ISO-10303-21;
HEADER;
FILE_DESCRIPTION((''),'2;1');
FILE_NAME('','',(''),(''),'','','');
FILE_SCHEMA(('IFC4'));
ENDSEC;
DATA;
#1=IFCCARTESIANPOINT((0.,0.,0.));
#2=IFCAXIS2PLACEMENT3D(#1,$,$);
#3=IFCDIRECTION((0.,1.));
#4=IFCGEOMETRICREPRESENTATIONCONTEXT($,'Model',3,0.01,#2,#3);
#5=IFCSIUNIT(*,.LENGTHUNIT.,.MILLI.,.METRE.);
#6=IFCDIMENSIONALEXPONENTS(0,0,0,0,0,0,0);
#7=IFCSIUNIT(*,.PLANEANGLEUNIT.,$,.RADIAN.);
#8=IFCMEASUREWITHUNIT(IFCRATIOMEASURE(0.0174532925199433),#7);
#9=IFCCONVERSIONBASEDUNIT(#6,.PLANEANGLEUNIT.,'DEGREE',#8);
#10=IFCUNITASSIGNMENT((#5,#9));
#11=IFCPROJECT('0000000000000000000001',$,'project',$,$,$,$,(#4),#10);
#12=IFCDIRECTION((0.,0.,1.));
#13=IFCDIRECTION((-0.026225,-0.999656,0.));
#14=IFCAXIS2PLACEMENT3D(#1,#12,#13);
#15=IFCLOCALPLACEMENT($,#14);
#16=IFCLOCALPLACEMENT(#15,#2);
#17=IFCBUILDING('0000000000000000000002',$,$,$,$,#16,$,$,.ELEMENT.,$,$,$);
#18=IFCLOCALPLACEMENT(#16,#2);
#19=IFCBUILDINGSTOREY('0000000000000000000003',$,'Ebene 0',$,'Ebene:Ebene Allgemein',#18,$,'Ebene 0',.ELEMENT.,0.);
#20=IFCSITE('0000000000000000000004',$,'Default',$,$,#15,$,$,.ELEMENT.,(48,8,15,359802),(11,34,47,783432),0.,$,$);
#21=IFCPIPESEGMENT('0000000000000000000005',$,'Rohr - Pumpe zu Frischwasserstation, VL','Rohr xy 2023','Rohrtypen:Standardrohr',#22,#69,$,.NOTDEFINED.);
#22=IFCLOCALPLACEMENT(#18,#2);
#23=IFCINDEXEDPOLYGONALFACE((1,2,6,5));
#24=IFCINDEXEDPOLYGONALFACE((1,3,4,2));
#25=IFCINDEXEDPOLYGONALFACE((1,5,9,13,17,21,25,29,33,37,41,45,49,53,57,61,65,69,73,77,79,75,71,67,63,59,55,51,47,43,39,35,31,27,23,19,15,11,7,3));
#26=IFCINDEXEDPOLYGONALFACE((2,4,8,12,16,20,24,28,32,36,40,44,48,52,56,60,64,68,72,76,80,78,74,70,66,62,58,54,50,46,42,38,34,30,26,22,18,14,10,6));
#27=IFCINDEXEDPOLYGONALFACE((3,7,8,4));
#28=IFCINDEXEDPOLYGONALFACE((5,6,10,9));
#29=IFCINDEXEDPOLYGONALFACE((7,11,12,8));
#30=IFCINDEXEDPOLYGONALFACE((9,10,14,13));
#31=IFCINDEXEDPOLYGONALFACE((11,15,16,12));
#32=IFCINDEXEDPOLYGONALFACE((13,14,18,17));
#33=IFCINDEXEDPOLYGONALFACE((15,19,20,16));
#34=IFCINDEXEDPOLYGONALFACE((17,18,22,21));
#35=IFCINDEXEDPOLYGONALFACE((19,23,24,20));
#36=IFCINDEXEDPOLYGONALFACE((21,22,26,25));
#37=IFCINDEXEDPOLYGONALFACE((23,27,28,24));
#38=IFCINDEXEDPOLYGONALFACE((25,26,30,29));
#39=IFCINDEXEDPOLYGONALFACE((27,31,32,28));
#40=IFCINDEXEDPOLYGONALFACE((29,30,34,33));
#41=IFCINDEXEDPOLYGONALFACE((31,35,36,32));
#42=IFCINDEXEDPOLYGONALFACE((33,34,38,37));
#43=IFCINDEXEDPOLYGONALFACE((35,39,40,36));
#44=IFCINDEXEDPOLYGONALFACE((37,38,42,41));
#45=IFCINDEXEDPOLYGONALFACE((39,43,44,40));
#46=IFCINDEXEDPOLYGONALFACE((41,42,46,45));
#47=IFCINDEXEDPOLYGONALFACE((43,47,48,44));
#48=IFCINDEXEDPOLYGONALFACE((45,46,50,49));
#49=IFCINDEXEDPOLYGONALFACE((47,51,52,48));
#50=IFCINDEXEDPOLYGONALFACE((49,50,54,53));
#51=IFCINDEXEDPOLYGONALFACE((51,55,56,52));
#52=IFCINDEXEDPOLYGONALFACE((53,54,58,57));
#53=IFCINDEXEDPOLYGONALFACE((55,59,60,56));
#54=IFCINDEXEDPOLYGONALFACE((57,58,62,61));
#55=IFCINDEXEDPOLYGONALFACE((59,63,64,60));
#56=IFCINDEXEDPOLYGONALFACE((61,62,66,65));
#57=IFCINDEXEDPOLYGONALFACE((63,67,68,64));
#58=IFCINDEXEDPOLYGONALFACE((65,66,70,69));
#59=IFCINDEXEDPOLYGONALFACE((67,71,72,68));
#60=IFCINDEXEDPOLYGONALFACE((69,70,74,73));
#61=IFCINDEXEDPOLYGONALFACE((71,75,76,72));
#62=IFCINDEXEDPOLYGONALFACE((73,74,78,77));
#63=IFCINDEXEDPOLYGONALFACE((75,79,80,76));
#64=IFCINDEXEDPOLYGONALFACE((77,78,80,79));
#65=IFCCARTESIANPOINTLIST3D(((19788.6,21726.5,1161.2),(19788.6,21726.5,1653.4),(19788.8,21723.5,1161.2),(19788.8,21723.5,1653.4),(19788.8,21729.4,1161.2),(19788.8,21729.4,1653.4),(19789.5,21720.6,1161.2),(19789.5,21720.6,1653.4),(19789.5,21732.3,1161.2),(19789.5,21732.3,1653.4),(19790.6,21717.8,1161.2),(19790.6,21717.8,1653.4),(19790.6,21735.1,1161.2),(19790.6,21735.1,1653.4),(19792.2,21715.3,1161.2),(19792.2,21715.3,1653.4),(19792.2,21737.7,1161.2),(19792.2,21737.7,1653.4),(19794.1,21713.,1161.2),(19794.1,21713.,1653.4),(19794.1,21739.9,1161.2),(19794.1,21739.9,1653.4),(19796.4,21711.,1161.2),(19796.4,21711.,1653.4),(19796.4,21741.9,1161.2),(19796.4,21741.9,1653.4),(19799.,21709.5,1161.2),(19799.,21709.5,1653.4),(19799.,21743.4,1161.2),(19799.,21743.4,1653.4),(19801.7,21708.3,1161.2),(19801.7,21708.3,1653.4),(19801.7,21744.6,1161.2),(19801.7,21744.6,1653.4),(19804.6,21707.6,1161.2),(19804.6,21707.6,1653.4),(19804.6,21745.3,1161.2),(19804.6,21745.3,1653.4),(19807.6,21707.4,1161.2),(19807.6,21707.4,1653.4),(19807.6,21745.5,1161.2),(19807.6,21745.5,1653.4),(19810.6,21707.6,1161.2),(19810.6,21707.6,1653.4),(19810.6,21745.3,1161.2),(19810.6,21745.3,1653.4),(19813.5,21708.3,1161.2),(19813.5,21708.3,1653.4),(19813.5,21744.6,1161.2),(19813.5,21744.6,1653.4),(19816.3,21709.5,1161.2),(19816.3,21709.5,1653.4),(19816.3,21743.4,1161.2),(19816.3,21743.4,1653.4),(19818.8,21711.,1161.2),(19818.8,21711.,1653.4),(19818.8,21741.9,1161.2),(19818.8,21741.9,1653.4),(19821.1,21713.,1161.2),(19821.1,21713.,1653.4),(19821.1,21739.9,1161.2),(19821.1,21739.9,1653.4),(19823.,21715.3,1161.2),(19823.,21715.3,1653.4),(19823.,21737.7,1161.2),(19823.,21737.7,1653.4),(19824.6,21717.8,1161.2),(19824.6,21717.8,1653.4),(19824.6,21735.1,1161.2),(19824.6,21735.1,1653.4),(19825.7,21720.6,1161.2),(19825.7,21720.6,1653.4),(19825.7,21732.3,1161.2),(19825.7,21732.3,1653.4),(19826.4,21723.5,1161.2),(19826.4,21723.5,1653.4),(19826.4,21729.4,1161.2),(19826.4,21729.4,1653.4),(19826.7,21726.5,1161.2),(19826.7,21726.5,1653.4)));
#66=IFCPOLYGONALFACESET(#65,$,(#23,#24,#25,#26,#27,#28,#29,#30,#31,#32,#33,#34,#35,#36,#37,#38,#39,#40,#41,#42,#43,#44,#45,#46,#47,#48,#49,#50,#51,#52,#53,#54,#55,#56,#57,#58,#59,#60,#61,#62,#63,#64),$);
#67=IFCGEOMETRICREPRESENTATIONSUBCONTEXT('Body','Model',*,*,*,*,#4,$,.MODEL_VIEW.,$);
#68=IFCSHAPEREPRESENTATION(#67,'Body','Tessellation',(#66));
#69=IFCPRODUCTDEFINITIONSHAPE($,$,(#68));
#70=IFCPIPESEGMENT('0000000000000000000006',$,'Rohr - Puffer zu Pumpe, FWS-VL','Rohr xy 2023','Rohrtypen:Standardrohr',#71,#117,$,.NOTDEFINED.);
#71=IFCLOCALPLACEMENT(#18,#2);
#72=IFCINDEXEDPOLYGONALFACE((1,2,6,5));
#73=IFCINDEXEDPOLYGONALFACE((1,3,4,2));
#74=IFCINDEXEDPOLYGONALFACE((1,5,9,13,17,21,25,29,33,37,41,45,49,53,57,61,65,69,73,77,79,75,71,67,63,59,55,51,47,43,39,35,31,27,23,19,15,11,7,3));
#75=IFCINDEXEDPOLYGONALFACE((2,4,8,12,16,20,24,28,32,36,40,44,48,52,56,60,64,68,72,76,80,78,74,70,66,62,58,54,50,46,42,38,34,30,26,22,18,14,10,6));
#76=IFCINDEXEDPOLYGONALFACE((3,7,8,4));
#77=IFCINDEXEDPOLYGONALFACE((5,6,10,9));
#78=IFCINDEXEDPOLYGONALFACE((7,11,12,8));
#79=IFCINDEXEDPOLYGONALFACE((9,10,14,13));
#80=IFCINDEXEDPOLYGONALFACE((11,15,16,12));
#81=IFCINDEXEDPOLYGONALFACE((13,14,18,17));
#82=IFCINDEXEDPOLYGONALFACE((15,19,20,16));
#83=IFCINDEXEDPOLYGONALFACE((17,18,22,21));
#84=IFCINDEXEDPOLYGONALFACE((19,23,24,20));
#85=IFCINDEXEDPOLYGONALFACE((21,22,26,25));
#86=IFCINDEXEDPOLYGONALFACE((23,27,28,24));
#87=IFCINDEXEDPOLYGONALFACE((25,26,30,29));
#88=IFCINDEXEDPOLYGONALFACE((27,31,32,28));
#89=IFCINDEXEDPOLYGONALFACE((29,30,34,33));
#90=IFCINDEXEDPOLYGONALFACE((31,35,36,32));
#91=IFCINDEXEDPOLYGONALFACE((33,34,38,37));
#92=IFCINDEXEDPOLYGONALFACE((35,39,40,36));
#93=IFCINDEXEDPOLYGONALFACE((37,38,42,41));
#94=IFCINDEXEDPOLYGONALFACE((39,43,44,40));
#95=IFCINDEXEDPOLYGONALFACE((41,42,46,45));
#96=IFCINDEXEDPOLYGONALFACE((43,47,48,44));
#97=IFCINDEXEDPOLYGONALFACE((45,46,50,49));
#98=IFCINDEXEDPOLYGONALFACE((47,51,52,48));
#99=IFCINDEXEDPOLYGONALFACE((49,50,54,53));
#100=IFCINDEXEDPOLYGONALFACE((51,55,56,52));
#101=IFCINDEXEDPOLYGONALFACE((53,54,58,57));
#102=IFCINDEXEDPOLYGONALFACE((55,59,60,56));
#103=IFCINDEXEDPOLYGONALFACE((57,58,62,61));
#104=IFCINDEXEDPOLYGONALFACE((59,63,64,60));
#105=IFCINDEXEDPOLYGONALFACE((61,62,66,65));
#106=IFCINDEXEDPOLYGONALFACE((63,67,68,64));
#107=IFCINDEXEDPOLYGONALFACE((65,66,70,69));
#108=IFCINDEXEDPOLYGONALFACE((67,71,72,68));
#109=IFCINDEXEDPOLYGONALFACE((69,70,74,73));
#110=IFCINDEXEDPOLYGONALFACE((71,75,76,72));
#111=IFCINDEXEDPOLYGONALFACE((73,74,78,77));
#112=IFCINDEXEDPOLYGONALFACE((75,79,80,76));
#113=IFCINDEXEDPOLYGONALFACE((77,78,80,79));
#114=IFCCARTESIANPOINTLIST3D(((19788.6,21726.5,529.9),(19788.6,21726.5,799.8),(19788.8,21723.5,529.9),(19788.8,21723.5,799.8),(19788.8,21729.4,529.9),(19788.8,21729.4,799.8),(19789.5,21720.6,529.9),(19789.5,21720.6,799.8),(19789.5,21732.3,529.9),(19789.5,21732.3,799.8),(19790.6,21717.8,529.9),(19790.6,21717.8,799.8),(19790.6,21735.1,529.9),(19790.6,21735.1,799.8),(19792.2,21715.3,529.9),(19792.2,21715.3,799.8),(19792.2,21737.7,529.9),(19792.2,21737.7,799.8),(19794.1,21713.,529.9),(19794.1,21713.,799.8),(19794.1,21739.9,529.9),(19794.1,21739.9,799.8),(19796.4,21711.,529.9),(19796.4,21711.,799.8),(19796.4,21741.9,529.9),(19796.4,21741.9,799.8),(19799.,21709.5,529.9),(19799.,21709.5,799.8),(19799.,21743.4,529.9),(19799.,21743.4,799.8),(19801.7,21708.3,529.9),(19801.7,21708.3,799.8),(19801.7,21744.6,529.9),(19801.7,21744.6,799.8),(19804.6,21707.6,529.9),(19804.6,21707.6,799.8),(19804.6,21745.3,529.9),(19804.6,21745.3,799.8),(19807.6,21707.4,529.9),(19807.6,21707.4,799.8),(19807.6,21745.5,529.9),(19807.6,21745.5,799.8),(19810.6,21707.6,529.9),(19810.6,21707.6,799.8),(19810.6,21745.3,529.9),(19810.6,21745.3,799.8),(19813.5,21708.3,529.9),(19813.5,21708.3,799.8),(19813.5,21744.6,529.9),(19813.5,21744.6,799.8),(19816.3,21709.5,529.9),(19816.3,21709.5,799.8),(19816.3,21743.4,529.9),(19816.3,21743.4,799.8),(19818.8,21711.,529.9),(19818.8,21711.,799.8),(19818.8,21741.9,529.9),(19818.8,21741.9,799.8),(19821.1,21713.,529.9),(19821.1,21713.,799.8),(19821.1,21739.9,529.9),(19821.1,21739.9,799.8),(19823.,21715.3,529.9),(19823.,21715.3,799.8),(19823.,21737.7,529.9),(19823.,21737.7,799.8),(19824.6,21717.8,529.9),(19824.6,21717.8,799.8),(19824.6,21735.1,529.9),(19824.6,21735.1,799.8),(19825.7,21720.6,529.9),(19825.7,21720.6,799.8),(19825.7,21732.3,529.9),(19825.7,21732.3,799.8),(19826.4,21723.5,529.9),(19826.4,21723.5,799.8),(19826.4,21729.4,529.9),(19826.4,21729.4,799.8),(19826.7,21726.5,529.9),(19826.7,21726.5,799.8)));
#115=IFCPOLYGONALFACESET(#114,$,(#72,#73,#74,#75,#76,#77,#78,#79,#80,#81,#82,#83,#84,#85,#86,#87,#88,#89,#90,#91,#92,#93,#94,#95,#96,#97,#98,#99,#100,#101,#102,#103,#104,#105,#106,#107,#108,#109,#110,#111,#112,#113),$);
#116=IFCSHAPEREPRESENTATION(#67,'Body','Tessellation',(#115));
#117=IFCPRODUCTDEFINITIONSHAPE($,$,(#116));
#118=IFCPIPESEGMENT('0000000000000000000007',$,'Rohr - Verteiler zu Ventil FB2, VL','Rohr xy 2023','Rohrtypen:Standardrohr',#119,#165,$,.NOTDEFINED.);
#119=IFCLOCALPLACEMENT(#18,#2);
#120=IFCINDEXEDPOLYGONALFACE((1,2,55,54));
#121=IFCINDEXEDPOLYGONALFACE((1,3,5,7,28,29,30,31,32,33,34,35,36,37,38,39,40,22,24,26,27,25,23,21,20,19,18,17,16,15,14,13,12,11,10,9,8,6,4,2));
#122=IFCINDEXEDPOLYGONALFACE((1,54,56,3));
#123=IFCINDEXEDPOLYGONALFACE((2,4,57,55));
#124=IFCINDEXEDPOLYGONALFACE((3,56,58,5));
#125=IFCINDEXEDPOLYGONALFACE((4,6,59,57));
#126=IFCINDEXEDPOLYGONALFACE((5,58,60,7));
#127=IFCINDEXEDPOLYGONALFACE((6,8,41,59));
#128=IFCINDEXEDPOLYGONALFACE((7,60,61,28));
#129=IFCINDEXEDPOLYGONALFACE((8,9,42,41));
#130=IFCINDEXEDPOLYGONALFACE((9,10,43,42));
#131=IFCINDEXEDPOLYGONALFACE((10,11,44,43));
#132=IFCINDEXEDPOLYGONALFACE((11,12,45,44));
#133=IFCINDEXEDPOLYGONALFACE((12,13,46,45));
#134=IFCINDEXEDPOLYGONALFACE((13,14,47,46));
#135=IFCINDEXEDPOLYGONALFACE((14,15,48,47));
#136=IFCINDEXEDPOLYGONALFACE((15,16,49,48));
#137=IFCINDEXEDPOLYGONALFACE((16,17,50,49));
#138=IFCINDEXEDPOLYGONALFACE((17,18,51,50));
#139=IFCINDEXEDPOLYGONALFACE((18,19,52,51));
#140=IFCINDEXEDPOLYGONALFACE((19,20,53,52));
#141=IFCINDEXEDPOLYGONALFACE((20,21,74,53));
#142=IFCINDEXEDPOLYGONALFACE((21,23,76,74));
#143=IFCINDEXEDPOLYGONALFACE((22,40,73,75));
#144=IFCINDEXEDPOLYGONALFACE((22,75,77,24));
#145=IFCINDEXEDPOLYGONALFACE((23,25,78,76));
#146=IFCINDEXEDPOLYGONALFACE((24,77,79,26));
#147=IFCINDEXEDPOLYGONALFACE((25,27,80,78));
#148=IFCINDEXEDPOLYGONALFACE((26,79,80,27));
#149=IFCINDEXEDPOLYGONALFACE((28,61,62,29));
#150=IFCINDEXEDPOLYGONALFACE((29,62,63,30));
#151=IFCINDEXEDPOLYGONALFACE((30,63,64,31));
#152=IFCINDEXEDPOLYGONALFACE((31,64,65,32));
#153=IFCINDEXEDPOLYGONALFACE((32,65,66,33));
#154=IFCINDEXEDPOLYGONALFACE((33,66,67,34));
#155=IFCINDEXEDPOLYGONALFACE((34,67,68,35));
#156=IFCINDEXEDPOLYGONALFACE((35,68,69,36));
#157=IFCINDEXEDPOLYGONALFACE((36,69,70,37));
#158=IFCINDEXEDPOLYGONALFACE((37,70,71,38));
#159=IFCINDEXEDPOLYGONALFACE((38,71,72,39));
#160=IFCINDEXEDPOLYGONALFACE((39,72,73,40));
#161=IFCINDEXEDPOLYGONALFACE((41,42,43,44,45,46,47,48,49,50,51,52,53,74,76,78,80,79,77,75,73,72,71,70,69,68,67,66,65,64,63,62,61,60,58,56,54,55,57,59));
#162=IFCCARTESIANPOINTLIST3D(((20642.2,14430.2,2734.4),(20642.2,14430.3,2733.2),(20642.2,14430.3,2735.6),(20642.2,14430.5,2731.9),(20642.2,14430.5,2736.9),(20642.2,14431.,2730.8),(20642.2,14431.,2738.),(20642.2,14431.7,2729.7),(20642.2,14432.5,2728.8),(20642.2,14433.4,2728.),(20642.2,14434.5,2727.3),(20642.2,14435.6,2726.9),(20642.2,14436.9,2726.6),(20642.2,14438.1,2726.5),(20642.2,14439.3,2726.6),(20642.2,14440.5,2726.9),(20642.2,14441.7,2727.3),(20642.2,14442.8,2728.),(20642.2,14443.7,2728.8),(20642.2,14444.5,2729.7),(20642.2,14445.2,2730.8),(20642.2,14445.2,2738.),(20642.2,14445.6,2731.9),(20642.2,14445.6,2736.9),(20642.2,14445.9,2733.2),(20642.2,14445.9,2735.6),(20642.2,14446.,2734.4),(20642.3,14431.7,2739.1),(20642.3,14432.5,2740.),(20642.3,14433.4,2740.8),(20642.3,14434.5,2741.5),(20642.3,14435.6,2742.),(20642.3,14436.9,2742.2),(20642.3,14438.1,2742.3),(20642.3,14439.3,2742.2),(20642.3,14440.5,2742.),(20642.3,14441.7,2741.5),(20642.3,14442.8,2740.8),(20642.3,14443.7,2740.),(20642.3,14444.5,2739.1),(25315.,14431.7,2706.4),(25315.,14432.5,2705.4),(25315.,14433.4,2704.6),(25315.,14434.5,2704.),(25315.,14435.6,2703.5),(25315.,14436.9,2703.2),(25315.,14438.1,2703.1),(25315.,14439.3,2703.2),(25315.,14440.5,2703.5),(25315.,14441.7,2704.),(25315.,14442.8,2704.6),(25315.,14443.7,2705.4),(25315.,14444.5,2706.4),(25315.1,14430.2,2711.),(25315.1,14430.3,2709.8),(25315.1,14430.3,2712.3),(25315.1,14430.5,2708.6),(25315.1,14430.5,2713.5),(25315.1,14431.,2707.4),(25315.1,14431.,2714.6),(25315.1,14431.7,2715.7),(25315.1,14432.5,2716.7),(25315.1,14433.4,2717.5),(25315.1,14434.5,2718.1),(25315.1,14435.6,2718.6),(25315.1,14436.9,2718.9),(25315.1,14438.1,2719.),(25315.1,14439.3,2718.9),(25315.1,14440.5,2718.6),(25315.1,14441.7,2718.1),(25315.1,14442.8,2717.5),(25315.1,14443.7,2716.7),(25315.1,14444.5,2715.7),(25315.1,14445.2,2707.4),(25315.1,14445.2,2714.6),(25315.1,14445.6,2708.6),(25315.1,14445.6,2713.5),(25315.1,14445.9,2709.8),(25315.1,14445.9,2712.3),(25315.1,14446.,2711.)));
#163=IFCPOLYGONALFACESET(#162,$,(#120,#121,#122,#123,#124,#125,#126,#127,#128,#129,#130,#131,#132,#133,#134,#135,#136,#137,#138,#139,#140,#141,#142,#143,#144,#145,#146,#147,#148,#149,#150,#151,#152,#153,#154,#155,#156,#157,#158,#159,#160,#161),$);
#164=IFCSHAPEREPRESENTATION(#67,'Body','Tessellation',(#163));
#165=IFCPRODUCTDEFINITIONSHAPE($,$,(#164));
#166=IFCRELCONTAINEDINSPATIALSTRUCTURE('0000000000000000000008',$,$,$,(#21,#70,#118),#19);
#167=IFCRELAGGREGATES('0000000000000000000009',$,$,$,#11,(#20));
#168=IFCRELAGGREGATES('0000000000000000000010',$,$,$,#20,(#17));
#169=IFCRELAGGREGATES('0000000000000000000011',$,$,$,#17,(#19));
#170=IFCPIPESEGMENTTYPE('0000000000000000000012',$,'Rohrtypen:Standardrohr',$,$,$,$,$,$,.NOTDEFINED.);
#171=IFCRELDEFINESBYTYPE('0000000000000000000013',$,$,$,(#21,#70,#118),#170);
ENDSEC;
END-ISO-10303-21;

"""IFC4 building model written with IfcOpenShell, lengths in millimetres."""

from ifc_helpers import new_model, entity, si_unit, converted_unit, direction, frame, origin, place, context, subcontext, project, spatial, indexed_curve, outline, extrude, type_object, element, save


model = new_model("IFC4")

# Units and contexts
model_context = context("Model", 3, precision=0.01, world=origin(), true_north=direction((0.0, 1.0)))
body_context = subcontext(model_context, "Body", "Model", "MODEL_VIEW")
ifc_project = project(units=[si_unit("LENGTHUNIT", "METRE", prefix="MILLI"), converted_unit("PLANEANGLEUNIT", "DEGREE", entity("IfcRatioMeasure", 0.0174532925199433), si_unit("PLANEANGLEUNIT", "RADIAN"), dimensions=[0, 0, 0, 0, 0, 0, 0])], contexts=[model_context])

# Site, building, storey
site_placement = place(None, frame((0.0, 0.0, 0.0), z_axis=(0.0, 0.0, 1.0), x_axis=(-0.026225, -0.999656, 0.0)))
site = spatial("IfcSite", under=ifc_project, at=site_placement, Name="Default", CompositionType="ELEMENT", RefLatitude=(48, 8, 15, 359802), RefLongitude=(11, 34, 47, 783432), RefElevation=0.0)
building_placement = place(site_placement, origin())
building = spatial("IfcBuilding", under=site, at=building_placement, CompositionType="ELEMENT")
storey_placement = place(building_placement, origin())
storey = spatial("IfcBuildingStorey", under=building, at=storey_placement, Name="Ebene 0", ObjectType="Ebene:Ebene Allgemein", LongName="Ebene 0", CompositionType="ELEMENT", Elevation=0.0)

# Pipe segments
pipe_segment_type = type_object("IfcPipeSegmentType", Name="Rohrtypen:Standardrohr", PredefinedType="NOTDEFINED")
pipe_segment_1_placement = place(storey_placement, origin())
element("IfcPipeSegment", 1, at=pipe_segment_1_placement, inside=storey, type_object=pipe_segment_type, Name="Rohr - Pumpe zu Frischwasserstation, VL", Description="Rohr xy 2023", ObjectType="Rohrtypen:Standardrohr", PredefinedType="NOTDEFINED", context=body_context, shape_type="SweptSolid", body=[
    extrude(outline(indexed_curve([(19.1, 0.0), (18.8, 3.0), (18.1, 5.9), (17.0, 8.6), (15.4, 11.2), (13.5, 13.5), (11.2, 15.4), (8.6, 17.0), (5.9, 18.1), (3.0, 18.8), (0.0, 19.0), (-3.0, 18.8), (-5.9, 18.1), (-8.6, 17.0), (-11.2, 15.4), (-13.5, 13.5), (-15.4, 11.2), (-17.0, 8.6), (-18.1, 5.9), (-18.8, 3.0), (-19.1, 0.0), (-18.8, -3.0), (-18.1, -5.9), (-17.0, -8.6), (-15.4, -11.2), (-13.5, -13.5), (-11.2, -15.4), (-8.6, -17.0), (-5.9, -18.1), (-3.0, -18.8), (0.0, -19.0), (3.0, -18.8), (5.9, -18.1), (8.6, -17.0), (11.2, -15.4), (13.5, -13.5), (15.4, -11.2), (17.0, -8.6), (18.1, -5.9), (18.8, -3.0), (19.1, 0.0)], self_intersect=False)), frame((19807.6, 21726.5, 1161.2), z_axis=(0.000002, 0.000002, 1.0), x_axis=(-1.0, 0.0, 0.000002)), (0.0, 0.0, 1.0), 492.1),
])
pipe_segment_2_placement = place(storey_placement, origin())
element("IfcPipeSegment", 2, at=pipe_segment_2_placement, inside=storey, type_object=pipe_segment_type, Name="Rohr - Puffer zu Pumpe, FWS-VL", Description="Rohr xy 2023", ObjectType="Rohrtypen:Standardrohr", PredefinedType="NOTDEFINED", context=body_context, shape_type="SweptSolid", body=[
    extrude(outline(indexed_curve([(19.1, 0.0), (18.8, 3.0), (18.1, 5.9), (17.0, 8.6), (15.4, 11.2), (13.5, 13.5), (11.2, 15.4), (8.6, 17.0), (5.9, 18.1), (3.0, 18.8), (0.0, 19.0), (-3.0, 18.8), (-5.9, 18.1), (-8.6, 17.0), (-11.2, 15.4), (-13.5, 13.5), (-15.4, 11.2), (-17.0, 8.6), (-18.1, 5.9), (-18.8, 3.0), (-19.1, 0.0), (-18.8, -3.0), (-18.1, -5.9), (-17.0, -8.6), (-15.4, -11.2), (-13.5, -13.5), (-11.2, -15.4), (-8.6, -17.0), (-5.9, -18.1), (-3.0, -18.8), (0.0, -19.0), (3.0, -18.8), (5.9, -18.1), (8.6, -17.0), (11.2, -15.4), (13.5, -13.5), (15.4, -11.2), (17.0, -8.6), (18.1, -5.9), (18.8, -3.0), (19.1, 0.0)], self_intersect=False)), frame((19807.6, 21726.5, 529.9), z_axis=(0.000002, 0.000002, 1.0), x_axis=(-1.0, 0.0, 0.000002)), (0.0, 0.0, 1.0), 269.9),
])
pipe_segment_3_placement = place(storey_placement, origin())
element("IfcPipeSegment", 3, at=pipe_segment_3_placement, inside=storey, type_object=pipe_segment_type, Name="Rohr - Verteiler zu Ventil FB2, VL", Description="Rohr xy 2023", ObjectType="Rohrtypen:Standardrohr", PredefinedType="NOTDEFINED", context=body_context, shape_type="SweptSolid", body=[
    extrude(outline(indexed_curve([(7.9, 0.0), (7.8, 1.2), (7.6, 2.5), (7.1, 3.6), (6.4, 4.7), (5.6, 5.6), (4.7, 6.4), (3.6, 7.1), (2.5, 7.6), (1.2, 7.8), (0.0, 7.9), (-1.2, 7.8), (-2.5, 7.6), (-3.6, 7.1), (-4.7, 6.4), (-5.6, 5.6), (-6.4, 4.7), (-7.1, 3.6), (-7.6, 2.5), (-7.8, 1.2), (-7.9, 0.0), (-7.8, -1.2), (-7.6, -2.5), (-7.1, -3.6), (-6.4, -4.7), (-5.6, -5.6), (-4.7, -6.4), (-3.6, -7.1), (-2.5, -7.6), (-1.2, -7.8), (0.0, -7.9), (1.2, -7.8), (2.5, -7.6), (3.6, -7.1), (4.7, -6.4), (5.6, -5.6), (6.4, -4.7), (7.1, -3.6), (7.6, -2.5), (7.8, -1.2), (7.9, 0.0)], self_intersect=False)), frame((25315.1, 14438.1, 2711.0), z_axis=(-0.999988, 0.0, 0.005), x_axis=(0.0, 1.0, 0.0)), (0.0, 0.0, 1.0), 4672.9),
])

save(model, "model.ifc")
